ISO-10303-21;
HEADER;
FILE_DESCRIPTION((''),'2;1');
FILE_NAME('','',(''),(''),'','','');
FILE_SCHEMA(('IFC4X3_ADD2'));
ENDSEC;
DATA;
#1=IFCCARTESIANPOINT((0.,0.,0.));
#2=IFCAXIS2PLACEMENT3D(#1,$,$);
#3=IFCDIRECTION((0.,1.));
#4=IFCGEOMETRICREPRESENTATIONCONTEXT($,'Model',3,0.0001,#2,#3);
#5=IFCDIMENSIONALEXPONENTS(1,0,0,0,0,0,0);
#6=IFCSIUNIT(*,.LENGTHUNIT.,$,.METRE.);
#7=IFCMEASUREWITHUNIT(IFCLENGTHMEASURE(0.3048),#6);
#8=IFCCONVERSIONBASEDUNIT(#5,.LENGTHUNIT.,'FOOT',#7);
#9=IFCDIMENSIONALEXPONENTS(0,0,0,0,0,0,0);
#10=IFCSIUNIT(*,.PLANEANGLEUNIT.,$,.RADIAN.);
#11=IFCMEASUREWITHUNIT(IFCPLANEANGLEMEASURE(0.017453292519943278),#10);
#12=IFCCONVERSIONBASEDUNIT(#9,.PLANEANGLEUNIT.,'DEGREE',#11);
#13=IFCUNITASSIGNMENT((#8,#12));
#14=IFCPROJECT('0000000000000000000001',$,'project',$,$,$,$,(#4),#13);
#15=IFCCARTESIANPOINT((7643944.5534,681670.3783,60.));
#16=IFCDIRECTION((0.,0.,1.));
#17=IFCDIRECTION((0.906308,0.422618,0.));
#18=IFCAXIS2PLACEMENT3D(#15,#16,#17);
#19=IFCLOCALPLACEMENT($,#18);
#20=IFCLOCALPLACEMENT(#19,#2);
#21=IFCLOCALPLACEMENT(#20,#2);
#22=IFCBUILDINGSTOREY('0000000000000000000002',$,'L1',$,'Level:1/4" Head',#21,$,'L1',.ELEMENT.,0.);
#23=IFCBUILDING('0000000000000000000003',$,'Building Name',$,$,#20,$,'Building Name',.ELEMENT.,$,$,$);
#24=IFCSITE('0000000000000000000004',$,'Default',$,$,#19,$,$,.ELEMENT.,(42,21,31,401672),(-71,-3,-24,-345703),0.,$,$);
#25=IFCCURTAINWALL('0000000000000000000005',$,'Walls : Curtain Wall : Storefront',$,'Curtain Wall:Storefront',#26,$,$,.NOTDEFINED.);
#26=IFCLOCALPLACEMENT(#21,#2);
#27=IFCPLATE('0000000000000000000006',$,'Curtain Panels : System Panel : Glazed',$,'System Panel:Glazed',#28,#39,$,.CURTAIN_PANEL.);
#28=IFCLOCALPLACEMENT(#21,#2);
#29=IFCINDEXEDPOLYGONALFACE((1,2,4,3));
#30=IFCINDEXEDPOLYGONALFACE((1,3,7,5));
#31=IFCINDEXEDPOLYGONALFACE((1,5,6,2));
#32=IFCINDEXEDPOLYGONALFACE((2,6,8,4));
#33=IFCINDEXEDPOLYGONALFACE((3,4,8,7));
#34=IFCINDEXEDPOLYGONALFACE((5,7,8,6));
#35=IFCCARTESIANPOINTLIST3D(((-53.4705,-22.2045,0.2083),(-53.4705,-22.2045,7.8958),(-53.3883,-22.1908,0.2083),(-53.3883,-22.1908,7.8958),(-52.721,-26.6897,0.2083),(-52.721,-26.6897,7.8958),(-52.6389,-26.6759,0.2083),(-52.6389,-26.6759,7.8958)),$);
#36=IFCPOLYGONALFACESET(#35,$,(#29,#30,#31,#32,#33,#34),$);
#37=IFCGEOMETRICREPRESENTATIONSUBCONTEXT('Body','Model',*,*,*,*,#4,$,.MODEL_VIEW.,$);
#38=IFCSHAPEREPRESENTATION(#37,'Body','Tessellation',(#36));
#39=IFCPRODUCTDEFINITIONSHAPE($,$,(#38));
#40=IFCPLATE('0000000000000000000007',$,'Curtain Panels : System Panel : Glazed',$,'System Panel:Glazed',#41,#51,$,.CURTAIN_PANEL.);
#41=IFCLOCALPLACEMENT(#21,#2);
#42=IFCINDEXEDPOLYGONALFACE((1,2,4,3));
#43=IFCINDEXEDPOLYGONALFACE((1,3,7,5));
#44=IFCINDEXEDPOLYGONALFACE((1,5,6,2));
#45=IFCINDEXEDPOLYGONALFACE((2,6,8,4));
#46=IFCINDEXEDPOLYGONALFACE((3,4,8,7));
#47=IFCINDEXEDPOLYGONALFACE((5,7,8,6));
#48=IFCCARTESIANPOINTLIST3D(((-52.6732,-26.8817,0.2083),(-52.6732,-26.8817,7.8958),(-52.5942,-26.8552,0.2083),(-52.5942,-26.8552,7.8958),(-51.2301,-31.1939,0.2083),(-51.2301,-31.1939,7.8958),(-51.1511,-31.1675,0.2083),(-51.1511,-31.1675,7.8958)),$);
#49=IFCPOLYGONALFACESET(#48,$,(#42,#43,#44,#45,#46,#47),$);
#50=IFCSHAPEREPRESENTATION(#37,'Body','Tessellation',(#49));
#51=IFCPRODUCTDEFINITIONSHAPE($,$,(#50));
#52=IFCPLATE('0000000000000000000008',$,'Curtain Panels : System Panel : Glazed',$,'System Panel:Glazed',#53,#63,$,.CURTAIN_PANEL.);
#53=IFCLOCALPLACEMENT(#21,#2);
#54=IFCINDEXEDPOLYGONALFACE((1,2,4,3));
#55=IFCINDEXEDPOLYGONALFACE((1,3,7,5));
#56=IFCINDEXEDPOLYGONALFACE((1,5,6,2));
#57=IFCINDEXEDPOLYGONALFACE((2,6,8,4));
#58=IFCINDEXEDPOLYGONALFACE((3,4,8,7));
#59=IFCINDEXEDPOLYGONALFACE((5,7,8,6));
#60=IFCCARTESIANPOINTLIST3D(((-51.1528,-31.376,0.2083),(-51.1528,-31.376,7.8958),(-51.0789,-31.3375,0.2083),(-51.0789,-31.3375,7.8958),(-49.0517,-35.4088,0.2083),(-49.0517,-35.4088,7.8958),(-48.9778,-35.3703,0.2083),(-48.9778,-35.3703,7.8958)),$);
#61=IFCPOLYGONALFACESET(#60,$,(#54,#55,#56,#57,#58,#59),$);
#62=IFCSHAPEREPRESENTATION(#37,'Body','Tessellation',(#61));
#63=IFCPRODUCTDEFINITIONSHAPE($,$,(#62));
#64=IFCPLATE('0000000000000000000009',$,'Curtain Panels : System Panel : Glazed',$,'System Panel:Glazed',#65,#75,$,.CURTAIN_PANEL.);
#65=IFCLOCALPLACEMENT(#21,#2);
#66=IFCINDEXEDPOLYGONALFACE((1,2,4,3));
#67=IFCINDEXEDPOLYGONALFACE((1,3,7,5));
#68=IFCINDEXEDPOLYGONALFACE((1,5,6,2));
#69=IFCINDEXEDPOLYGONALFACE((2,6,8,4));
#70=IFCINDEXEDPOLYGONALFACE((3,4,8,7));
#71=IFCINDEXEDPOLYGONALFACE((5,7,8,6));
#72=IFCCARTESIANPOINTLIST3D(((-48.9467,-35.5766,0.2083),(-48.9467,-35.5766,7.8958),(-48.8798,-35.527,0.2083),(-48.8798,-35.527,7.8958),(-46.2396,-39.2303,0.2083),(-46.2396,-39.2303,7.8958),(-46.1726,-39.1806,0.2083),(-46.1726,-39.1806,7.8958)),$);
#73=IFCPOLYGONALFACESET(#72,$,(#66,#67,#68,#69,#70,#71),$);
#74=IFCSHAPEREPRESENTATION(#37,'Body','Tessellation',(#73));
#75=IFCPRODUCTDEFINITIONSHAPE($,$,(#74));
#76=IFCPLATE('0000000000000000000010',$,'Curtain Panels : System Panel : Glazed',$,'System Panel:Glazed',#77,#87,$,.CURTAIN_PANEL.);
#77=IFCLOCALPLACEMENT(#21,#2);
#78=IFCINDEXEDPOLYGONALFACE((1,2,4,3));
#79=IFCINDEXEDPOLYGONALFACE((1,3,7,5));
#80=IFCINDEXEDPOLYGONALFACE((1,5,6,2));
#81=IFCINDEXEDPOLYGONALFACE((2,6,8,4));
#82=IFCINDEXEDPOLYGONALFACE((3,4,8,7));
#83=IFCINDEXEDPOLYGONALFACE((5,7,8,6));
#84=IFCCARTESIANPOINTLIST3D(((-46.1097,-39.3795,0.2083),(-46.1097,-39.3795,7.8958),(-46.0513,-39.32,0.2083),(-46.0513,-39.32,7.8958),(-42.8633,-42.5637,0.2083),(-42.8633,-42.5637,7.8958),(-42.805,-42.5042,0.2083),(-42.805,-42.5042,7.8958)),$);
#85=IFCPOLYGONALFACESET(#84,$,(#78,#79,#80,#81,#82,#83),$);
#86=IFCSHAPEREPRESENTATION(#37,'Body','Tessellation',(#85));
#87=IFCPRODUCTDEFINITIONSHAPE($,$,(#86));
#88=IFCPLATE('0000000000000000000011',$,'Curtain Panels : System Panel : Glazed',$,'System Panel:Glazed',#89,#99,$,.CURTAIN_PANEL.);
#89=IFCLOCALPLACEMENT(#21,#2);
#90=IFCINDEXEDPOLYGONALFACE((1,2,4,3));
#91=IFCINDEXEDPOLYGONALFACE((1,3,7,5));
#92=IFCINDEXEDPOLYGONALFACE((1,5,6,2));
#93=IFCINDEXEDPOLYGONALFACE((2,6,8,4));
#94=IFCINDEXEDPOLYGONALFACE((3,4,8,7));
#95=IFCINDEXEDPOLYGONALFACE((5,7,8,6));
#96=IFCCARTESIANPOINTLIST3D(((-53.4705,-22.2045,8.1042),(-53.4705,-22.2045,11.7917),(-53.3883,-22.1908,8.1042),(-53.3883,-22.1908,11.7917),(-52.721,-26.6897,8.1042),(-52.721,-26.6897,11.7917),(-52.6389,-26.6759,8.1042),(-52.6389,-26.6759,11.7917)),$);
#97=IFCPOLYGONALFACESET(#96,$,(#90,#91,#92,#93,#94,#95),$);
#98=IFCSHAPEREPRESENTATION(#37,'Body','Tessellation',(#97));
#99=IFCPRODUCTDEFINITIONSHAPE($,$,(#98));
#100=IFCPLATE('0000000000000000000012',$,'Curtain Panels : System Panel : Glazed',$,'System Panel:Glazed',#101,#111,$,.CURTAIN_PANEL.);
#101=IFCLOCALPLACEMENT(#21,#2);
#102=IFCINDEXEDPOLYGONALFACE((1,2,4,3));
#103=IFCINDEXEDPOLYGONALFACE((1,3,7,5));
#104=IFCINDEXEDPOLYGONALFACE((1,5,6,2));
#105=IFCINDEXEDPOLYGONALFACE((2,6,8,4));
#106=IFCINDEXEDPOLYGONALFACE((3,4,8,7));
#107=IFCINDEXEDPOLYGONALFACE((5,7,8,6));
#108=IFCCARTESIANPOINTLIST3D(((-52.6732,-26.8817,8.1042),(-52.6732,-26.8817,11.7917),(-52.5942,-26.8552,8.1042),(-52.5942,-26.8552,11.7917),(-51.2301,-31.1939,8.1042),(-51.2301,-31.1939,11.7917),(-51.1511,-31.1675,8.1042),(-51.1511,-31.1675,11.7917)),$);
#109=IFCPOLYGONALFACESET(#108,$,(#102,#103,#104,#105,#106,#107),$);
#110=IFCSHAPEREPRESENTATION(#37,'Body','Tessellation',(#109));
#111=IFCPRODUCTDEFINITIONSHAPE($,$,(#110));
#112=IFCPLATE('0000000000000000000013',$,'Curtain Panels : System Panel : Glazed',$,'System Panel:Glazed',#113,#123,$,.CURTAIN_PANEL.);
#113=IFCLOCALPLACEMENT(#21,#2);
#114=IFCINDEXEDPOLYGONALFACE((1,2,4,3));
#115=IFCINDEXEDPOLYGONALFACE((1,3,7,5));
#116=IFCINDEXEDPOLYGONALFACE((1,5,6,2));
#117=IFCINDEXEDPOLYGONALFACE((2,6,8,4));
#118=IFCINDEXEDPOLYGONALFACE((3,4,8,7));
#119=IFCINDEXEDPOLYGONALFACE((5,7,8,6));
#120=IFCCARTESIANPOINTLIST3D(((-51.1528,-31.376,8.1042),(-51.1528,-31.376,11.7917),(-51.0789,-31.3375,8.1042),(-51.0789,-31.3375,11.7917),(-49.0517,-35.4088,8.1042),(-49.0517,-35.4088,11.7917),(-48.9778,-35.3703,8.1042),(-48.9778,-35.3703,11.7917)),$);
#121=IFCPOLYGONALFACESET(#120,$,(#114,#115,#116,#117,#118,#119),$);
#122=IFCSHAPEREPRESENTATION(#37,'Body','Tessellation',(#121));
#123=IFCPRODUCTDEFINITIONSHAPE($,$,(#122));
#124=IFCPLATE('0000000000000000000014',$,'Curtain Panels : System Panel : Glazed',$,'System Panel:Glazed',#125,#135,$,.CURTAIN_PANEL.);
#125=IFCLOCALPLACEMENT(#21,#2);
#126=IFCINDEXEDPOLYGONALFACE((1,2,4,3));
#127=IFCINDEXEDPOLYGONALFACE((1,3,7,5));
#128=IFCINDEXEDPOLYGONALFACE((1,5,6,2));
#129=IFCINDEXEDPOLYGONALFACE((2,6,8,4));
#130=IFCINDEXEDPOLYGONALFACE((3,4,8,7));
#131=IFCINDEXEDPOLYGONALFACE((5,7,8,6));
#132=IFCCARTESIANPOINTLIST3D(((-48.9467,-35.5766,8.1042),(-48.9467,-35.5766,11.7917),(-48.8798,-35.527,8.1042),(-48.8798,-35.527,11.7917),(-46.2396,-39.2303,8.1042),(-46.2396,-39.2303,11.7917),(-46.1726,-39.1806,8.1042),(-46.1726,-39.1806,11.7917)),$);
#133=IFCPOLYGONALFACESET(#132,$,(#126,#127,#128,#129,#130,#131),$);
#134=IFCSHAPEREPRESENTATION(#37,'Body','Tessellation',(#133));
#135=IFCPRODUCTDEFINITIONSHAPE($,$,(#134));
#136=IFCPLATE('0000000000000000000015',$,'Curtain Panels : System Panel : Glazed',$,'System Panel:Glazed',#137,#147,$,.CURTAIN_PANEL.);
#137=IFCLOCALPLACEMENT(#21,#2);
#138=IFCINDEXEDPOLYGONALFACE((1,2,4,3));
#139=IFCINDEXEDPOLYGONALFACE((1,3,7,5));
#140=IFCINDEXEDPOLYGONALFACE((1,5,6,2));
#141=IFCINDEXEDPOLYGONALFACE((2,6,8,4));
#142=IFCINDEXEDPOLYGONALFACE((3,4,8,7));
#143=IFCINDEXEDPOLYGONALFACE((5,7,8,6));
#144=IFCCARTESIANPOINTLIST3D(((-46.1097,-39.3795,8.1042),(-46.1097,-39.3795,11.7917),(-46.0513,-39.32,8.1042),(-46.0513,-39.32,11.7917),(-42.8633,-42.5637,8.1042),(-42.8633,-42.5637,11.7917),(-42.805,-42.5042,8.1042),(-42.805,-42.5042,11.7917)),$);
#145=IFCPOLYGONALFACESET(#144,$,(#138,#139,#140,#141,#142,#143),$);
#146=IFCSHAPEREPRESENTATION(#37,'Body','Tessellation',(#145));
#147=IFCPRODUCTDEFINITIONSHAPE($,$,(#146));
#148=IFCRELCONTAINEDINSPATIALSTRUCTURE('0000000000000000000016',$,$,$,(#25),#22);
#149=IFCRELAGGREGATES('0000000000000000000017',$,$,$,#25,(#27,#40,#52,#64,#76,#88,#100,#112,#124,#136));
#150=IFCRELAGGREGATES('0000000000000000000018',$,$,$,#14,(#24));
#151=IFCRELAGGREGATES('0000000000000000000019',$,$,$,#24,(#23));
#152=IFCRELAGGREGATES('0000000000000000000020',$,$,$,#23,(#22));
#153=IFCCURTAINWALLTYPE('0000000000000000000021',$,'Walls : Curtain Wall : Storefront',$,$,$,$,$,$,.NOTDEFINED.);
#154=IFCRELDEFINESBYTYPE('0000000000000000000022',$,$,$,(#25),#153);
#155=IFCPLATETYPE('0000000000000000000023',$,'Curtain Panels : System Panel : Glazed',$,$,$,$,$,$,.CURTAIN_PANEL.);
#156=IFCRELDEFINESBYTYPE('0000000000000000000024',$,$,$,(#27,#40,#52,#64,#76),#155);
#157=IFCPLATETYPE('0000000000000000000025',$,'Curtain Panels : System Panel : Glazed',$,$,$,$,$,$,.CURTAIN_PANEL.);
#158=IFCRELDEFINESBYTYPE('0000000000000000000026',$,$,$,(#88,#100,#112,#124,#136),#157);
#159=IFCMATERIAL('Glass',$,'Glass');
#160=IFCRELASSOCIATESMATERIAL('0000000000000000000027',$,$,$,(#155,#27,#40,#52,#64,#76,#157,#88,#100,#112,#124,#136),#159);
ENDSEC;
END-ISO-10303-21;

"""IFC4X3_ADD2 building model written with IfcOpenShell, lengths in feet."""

from ifc_helpers import new_model, entity, si_unit, converted_unit, direction, frame, frame_2d, origin, place, context, subcontext, project, spatial, rectangle, extrude, source, transform, mapped, material, type_object, type_shapes, element, aggregate, save


model = new_model("IFC4X3_ADD2")

# Units and contexts
model_context = context("Model", 3, precision=0.0001, world=origin(), true_north=direction((0.0, 1.0)))
body_context = subcontext(model_context, "Body", "Model", "MODEL_VIEW")
ifc_project = project(units=[converted_unit("LENGTHUNIT", "FOOT", entity("IfcLengthMeasure", 0.3048), si_unit("LENGTHUNIT", "METRE"), dimensions=[1, 0, 0, 0, 0, 0, 0]), converted_unit("PLANEANGLEUNIT", "DEGREE", entity("IfcPlaneAngleMeasure", 0.017453292519943278), si_unit("PLANEANGLEUNIT", "RADIAN"), dimensions=[0, 0, 0, 0, 0, 0, 0])], contexts=[model_context])

# Site, building, storey
site_placement = place(None, frame((7643944.5534, 681670.3783, 60.0), z_axis=(0.0, 0.0, 1.0), x_axis=(0.906308, 0.422618, 0.0)))
site = spatial("IfcSite", under=ifc_project, at=site_placement, Name="Default", CompositionType="ELEMENT", RefLatitude=(42, 21, 31, 401672), RefLongitude=(-71, -3, -24, -345703), RefElevation=0.0)
building_placement = place(site_placement, origin())
building = spatial("IfcBuilding", under=site, at=building_placement, Name="Building Name", LongName="Building Name", CompositionType="ELEMENT")
storey_placement = place(building_placement, origin())
storey = spatial("IfcBuildingStorey", under=building, at=storey_placement, Name="L1", ObjectType="Level:1/4\" Head", LongName="L1", CompositionType="ELEMENT", Elevation=0.0)

# Curtain wall, plates
curtain_wall_type = type_object("IfcCurtainWallType", Name="Walls : Curtain Wall : Storefront", PredefinedType="NOTDEFINED")
curtain_wall_placement = place(storey_placement, origin())
curtain_wall = element("IfcCurtainWall", 1, at=curtain_wall_placement, inside=storey, type_object=curtain_wall_type, Name="Walls : Curtain Wall : Storefront", ObjectType="Curtain Wall:Storefront", PredefinedType="NOTDEFINED")
ifc_material_1 = material(Name="Glass", Category="Glass")
plate_type_1 = type_object("IfcPlateType", Name="Curtain Panels : System Panel : Glazed", PredefinedType="CURTAIN_PANEL", material=ifc_material_1)
shared_shape_1 = source(origin(), body_context, "Body", "SweptSolid", [
    extrude(rectangle(XDim=0.0833, YDim=4.5473, at=frame_2d((0.0, 0.0), x_axis=(1.0, 0.0))), frame((2.2737, 0.0417, 0.0), z_axis=(0.0, 0.0, 1.0), x_axis=(0.0, 1.0, 0.0)), (0.0, 0.0, 1.0), 7.6875),
])
type_shapes(plate_type_1, [shared_shape_1])
plate_1_placement = place(curtain_wall_placement, frame((-53.4705, -22.2045, 0.2083), z_axis=(0.0, 0.0, 1.0), x_axis=(0.164805, -0.986326, 0.0)))
plate_1 = element("IfcPlate", 2, at=plate_1_placement, type_object=plate_type_1, material=ifc_material_1, Name="Curtain Panels : System Panel : Glazed", ObjectType="System Panel:Glazed", PredefinedType="CURTAIN_PANEL", context=body_context, shape_type="MappedRepresentation", body=[
    mapped(shared_shape_1, transform((0.0, 0.0, 0.0), scale=1.0)),
])
plate_2_placement = place(curtain_wall_placement, frame((-52.6732, -26.8817, 0.2083), z_axis=(0.0, 0.0, 1.0), x_axis=(0.31735, -0.948308, 0.0)))
plate_2 = element("IfcPlate", 3, at=plate_2_placement, type_object=plate_type_1, material=ifc_material_1, Name="Curtain Panels : System Panel : Glazed", ObjectType="System Panel:Glazed", PredefinedType="CURTAIN_PANEL", context=body_context, shape_type="MappedRepresentation", body=[
    mapped(shared_shape_1, transform((0.0, 0.0, 0.0), scale=1.0)),
])
plate_3_placement = place(curtain_wall_placement, frame((-51.1528, -31.376, 0.2083), z_axis=(0.0, 0.0, 1.0), x_axis=(0.462051, -0.886853, 0.0)))
plate_3 = element("IfcPlate", 4, at=plate_3_placement, type_object=plate_type_1, material=ifc_material_1, Name="Curtain Panels : System Panel : Glazed", ObjectType="System Panel:Glazed", PredefinedType="CURTAIN_PANEL", context=body_context, shape_type="MappedRepresentation", body=[
    mapped(shared_shape_1, transform((0.0, 0.0, 0.0), scale=1.0)),
])
plate_4_placement = place(curtain_wall_placement, frame((-48.9467, -35.5766, 0.2083), z_axis=(0.0, 0.0, 1.0), x_axis=(0.595333, -0.803479, 0.0)))
plate_4 = element("IfcPlate", 5, at=plate_4_placement, type_object=plate_type_1, material=ifc_material_1, Name="Curtain Panels : System Panel : Glazed", ObjectType="System Panel:Glazed", PredefinedType="CURTAIN_PANEL", context=body_context, shape_type="MappedRepresentation", body=[
    mapped(shared_shape_1, transform((0.0, 0.0, 0.0), scale=1.0)),
])
plate_5_placement = place(curtain_wall_placement, frame((-46.1097, -39.3795, 0.2083), z_axis=(0.0, 0.0, 1.0), x_axis=(0.713901, -0.700247, 0.0)))
plate_5 = element("IfcPlate", 6, at=plate_5_placement, type_object=plate_type_1, material=ifc_material_1, Name="Curtain Panels : System Panel : Glazed", ObjectType="System Panel:Glazed", PredefinedType="CURTAIN_PANEL", context=body_context, shape_type="MappedRepresentation", body=[
    mapped(shared_shape_1, transform((0.0, 0.0, 0.0), scale=1.0)),
])
plate_type_2 = type_object("IfcPlateType", Name="Curtain Panels : System Panel : Glazed", PredefinedType="CURTAIN_PANEL", material=ifc_material_1)
shared_shape_2 = source(origin(), body_context, "Body", "SweptSolid", [
    extrude(rectangle(XDim=0.0833, YDim=4.5473, at=frame_2d((0.0, 0.0), x_axis=(1.0, 0.0))), frame((2.2737, 0.0417, 0.0), z_axis=(0.0, 0.0, 1.0), x_axis=(0.0, 1.0, 0.0)), (0.0, 0.0, 1.0), 3.6875),
])
type_shapes(plate_type_2, [shared_shape_2])
plate_6_placement = place(curtain_wall_placement, frame((-53.4705, -22.2045, 8.1042), z_axis=(0.0, 0.0, 1.0), x_axis=(0.164805, -0.986326, 0.0)))
plate_6 = element("IfcPlate", 7, at=plate_6_placement, type_object=plate_type_2, material=ifc_material_1, Name="Curtain Panels : System Panel : Glazed", ObjectType="System Panel:Glazed", PredefinedType="CURTAIN_PANEL", context=body_context, shape_type="MappedRepresentation", body=[
    mapped(shared_shape_2, transform((0.0, 0.0, 0.0), scale=1.0)),
])
plate_7_placement = place(curtain_wall_placement, frame((-52.6732, -26.8817, 8.1042), z_axis=(0.0, 0.0, 1.0), x_axis=(0.31735, -0.948308, 0.0)))
plate_7 = element("IfcPlate", 8, at=plate_7_placement, type_object=plate_type_2, material=ifc_material_1, Name="Curtain Panels : System Panel : Glazed", ObjectType="System Panel:Glazed", PredefinedType="CURTAIN_PANEL", context=body_context, shape_type="MappedRepresentation", body=[
    mapped(shared_shape_2, transform((0.0, 0.0, 0.0), scale=1.0)),
])
plate_8_placement = place(curtain_wall_placement, frame((-51.1528, -31.376, 8.1042), z_axis=(0.0, 0.0, 1.0), x_axis=(0.462051, -0.886853, 0.0)))
plate_8 = element("IfcPlate", 9, at=plate_8_placement, type_object=plate_type_2, material=ifc_material_1, Name="Curtain Panels : System Panel : Glazed", ObjectType="System Panel:Glazed", PredefinedType="CURTAIN_PANEL", context=body_context, shape_type="MappedRepresentation", body=[
    mapped(shared_shape_2, transform((0.0, 0.0, 0.0), scale=1.0)),
])
plate_9_placement = place(curtain_wall_placement, frame((-48.9467, -35.5766, 8.1042), z_axis=(0.0, 0.0, 1.0), x_axis=(0.595333, -0.803479, 0.0)))
plate_9 = element("IfcPlate", 10, at=plate_9_placement, type_object=plate_type_2, material=ifc_material_1, Name="Curtain Panels : System Panel : Glazed", ObjectType="System Panel:Glazed", PredefinedType="CURTAIN_PANEL", context=body_context, shape_type="MappedRepresentation", body=[
    mapped(shared_shape_2, transform((0.0, 0.0, 0.0), scale=1.0)),
])
plate_10_placement = place(curtain_wall_placement, frame((-46.1097, -39.3795, 8.1042), z_axis=(0.0, 0.0, 1.0), x_axis=(0.713901, -0.700247, 0.0)))
plate_10 = element("IfcPlate", 11, at=plate_10_placement, type_object=plate_type_2, material=ifc_material_1, Name="Curtain Panels : System Panel : Glazed", ObjectType="System Panel:Glazed", PredefinedType="CURTAIN_PANEL", context=body_context, shape_type="MappedRepresentation", body=[
    mapped(shared_shape_2, transform((0.0, 0.0, 0.0), scale=1.0)),
])
aggregate(curtain_wall, [plate_1, plate_2, plate_3, plate_4, plate_5, plate_6, plate_7, plate_8, plate_9, plate_10])

save(model, "model.ifc")
